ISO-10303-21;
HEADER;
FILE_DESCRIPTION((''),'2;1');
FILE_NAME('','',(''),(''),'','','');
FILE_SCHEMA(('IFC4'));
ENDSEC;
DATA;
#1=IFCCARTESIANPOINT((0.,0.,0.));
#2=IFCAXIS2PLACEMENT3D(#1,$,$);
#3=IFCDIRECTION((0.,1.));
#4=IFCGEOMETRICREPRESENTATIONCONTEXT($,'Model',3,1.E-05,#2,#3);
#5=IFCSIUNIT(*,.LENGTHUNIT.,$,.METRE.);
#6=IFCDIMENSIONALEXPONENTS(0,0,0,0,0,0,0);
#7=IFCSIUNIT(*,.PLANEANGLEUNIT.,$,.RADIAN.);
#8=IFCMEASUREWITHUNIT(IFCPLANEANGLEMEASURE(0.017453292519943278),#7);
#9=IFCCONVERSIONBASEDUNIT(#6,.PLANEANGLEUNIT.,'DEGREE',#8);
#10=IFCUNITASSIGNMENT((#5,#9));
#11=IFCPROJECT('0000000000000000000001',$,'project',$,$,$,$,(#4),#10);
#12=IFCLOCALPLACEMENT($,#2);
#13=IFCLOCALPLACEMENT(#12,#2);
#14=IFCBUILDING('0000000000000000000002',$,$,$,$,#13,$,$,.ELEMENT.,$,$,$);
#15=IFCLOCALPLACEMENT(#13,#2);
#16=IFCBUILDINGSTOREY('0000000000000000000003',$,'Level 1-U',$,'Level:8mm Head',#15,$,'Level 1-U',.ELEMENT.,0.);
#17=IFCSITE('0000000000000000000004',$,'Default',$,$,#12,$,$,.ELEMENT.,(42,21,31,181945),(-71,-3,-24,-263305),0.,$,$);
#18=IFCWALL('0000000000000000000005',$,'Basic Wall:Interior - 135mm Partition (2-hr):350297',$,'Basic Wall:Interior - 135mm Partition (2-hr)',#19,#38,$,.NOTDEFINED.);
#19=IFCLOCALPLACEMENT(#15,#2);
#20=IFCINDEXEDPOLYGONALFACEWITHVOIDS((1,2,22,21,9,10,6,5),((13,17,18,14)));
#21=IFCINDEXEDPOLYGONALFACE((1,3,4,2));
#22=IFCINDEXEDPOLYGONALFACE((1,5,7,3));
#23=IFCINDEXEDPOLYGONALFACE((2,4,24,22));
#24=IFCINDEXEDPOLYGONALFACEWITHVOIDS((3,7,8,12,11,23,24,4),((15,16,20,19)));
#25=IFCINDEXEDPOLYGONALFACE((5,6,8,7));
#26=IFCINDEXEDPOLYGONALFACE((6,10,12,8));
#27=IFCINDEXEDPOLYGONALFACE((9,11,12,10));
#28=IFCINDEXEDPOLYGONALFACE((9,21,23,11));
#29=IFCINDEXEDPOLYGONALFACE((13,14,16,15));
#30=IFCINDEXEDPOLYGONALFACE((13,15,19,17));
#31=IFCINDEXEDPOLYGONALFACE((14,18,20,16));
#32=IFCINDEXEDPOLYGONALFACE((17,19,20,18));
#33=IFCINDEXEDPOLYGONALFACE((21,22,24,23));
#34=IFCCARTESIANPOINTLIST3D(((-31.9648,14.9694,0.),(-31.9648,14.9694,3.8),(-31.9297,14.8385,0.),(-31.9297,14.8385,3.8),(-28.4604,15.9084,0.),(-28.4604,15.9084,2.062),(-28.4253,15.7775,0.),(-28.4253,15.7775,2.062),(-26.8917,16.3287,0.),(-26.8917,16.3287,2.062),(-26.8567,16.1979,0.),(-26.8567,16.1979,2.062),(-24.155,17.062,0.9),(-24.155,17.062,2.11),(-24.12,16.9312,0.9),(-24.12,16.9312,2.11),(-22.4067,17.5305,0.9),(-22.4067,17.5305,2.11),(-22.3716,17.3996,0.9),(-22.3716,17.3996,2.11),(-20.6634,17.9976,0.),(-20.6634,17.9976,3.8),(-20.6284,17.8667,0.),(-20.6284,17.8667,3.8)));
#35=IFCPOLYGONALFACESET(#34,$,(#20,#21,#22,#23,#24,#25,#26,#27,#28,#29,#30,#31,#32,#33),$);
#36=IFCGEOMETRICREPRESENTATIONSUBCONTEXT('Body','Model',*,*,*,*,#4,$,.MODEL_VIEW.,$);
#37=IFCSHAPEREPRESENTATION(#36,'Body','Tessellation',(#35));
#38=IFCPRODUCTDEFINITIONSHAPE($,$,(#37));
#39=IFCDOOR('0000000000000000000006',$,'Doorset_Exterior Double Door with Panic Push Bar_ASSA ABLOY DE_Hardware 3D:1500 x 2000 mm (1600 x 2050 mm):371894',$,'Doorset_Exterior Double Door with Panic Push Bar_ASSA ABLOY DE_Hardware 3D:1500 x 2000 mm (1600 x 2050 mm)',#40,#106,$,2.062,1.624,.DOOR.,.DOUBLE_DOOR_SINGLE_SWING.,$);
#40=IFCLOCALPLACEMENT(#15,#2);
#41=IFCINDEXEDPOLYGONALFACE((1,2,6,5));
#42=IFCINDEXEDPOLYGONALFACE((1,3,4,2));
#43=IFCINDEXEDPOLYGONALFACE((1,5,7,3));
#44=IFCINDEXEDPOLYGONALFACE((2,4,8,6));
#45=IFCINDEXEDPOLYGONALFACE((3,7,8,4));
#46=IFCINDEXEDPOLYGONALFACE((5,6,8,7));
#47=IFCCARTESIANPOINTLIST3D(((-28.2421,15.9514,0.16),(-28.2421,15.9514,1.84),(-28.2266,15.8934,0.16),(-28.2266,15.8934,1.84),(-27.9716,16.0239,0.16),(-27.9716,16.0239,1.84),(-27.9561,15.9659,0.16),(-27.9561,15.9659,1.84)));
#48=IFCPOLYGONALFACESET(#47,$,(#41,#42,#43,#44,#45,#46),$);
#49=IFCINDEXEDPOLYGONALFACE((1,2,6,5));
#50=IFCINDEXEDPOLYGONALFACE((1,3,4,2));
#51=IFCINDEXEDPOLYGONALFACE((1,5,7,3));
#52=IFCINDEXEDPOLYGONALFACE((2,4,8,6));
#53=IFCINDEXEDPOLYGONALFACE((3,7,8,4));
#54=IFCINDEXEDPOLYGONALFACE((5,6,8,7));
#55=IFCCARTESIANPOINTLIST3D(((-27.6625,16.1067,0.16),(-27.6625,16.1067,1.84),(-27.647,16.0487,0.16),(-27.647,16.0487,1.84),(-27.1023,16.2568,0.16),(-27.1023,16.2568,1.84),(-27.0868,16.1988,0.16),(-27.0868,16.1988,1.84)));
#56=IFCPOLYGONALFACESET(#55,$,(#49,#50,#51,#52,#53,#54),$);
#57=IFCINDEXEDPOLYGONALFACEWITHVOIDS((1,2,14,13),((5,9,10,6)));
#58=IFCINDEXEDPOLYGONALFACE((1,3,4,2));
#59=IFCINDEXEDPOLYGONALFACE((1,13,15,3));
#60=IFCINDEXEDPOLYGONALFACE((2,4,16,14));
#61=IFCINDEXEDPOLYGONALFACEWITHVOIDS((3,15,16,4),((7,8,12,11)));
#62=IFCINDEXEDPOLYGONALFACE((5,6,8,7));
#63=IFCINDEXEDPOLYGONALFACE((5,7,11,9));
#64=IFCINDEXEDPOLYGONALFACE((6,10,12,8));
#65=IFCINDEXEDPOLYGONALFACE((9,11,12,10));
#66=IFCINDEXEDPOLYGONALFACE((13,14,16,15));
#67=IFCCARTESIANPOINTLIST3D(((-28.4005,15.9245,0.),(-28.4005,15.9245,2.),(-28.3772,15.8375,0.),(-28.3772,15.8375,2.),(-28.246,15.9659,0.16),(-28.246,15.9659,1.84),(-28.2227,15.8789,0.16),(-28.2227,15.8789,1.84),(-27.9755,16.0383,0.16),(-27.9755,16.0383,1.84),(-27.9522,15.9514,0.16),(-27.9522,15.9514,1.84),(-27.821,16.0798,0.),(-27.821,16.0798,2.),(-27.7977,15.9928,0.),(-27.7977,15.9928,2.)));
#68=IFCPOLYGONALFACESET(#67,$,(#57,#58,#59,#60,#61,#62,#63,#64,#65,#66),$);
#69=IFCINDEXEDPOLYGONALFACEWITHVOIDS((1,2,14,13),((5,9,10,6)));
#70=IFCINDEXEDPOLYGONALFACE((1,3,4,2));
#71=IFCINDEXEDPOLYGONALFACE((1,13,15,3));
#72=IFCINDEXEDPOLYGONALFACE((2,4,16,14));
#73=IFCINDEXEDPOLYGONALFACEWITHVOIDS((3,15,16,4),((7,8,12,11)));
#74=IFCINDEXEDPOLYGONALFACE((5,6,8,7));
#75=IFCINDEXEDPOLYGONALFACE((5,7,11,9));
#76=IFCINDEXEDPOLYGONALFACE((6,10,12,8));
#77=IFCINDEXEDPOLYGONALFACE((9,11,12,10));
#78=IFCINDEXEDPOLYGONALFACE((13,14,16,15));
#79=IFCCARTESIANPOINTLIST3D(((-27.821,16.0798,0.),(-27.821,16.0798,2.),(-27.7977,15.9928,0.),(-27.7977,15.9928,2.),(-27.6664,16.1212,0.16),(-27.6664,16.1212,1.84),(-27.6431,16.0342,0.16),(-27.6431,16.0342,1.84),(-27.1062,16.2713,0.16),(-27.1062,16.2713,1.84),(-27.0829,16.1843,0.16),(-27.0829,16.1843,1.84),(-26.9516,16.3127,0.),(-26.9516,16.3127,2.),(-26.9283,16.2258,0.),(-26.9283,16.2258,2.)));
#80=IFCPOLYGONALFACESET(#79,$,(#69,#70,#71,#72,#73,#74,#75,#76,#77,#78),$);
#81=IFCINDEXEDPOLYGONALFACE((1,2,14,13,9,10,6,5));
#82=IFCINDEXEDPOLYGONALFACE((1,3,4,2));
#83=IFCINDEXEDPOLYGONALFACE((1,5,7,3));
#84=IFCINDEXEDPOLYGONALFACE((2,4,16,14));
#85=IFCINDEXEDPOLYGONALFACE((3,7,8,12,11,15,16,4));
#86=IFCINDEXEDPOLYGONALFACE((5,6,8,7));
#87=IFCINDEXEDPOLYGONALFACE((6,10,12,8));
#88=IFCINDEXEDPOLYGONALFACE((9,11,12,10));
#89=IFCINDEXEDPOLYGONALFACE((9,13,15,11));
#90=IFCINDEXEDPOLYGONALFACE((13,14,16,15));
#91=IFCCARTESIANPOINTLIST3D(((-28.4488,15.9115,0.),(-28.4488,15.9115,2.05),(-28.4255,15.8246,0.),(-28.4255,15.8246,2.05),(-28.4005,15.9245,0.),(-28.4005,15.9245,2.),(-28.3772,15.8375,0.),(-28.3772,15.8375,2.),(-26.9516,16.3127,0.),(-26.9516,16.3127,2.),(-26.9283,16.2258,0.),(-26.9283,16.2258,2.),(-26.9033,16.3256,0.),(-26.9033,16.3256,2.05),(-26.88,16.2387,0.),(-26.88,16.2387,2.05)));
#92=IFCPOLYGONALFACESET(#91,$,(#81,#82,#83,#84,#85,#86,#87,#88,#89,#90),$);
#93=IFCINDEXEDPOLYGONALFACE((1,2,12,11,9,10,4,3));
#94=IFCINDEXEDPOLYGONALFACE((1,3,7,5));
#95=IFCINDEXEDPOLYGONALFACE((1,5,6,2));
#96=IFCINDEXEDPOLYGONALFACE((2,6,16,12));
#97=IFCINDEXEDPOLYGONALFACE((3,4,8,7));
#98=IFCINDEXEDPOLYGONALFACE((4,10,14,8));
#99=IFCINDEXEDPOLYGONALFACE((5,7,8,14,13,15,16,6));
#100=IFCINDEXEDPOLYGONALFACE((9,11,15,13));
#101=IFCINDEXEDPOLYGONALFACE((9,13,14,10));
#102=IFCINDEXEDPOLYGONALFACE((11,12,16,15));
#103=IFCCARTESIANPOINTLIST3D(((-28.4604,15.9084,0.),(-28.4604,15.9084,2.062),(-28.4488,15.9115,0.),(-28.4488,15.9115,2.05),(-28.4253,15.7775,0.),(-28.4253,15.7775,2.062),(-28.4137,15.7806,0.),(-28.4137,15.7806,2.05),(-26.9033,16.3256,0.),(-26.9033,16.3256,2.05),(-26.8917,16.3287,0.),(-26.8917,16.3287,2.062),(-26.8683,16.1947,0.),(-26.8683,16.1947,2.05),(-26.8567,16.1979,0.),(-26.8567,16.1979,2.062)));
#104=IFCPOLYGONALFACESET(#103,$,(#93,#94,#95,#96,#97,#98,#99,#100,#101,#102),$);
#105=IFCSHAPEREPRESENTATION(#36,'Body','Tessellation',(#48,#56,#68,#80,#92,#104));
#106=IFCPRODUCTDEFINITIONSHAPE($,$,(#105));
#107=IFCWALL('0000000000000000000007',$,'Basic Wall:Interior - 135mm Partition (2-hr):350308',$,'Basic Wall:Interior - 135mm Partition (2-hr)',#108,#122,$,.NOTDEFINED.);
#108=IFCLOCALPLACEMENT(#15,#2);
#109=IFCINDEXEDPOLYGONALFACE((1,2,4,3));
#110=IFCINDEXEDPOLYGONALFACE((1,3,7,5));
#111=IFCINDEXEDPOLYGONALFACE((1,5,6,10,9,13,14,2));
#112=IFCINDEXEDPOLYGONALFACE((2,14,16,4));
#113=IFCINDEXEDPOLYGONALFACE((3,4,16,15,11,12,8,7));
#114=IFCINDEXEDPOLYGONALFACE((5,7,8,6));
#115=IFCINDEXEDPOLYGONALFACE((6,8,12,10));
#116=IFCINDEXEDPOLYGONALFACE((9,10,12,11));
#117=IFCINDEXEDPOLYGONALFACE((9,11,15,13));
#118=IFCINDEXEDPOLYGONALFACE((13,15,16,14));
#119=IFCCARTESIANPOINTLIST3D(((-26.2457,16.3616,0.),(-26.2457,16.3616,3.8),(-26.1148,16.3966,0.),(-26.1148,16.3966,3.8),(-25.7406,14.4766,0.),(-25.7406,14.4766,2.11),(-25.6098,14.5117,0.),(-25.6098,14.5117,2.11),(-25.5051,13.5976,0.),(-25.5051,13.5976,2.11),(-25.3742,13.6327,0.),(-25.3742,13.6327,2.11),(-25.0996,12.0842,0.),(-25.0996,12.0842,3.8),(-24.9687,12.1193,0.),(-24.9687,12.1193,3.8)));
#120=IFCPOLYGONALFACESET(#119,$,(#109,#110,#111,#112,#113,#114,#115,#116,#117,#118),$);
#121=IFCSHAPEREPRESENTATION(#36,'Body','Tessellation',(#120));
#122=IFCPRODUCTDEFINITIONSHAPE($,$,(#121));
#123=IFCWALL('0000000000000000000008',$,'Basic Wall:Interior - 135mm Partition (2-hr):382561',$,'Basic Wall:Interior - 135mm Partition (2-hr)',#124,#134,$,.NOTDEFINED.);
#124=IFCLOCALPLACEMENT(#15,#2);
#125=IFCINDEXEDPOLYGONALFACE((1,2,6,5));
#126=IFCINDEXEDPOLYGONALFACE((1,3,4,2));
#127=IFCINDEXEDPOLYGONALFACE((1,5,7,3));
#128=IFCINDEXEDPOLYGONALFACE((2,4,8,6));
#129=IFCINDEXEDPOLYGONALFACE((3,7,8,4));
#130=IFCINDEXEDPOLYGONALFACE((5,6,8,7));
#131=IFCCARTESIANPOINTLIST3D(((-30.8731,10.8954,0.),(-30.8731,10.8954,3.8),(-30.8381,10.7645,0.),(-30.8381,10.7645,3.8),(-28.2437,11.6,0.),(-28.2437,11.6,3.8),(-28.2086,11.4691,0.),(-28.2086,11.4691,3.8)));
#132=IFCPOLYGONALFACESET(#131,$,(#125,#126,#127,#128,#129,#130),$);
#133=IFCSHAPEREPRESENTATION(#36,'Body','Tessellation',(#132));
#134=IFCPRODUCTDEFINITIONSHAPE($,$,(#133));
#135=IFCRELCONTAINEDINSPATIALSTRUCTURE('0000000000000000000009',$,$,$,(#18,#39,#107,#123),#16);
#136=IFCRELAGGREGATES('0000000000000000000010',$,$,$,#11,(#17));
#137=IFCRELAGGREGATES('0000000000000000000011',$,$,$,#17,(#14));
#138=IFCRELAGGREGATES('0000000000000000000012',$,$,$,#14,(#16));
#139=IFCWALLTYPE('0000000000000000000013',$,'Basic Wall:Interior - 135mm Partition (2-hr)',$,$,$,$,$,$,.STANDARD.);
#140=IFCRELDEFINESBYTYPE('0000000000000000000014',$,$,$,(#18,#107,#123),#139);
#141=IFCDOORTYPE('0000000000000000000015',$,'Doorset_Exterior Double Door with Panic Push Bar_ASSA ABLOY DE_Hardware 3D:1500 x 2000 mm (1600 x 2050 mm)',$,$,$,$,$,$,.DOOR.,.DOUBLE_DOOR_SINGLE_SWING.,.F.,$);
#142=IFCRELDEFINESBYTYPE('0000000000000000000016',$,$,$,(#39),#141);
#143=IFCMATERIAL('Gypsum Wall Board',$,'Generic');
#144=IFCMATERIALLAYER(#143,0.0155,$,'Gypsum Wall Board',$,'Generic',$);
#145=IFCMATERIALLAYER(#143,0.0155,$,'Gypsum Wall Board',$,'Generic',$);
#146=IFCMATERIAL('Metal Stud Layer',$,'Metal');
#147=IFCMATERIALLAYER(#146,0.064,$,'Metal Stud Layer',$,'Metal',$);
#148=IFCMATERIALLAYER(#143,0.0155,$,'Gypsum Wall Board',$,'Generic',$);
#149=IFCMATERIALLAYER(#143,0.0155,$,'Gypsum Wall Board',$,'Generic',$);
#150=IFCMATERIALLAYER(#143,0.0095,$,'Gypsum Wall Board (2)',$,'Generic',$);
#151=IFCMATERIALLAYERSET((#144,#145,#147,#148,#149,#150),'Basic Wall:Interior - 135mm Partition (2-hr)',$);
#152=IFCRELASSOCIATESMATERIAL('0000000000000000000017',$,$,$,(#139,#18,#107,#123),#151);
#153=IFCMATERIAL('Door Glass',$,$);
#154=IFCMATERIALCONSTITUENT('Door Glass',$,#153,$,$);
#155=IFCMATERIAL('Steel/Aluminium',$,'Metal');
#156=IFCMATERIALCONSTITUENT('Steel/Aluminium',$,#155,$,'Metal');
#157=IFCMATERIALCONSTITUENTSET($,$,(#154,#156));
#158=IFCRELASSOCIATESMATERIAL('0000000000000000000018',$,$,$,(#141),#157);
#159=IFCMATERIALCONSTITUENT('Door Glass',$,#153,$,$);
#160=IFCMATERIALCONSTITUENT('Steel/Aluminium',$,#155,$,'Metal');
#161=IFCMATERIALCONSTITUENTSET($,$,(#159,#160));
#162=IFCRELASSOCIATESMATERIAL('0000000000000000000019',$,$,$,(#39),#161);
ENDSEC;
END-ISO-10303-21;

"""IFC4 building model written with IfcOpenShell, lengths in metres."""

from ifc_helpers import new_model, entity, si_unit, converted_unit, direction, frame, frame_2d, origin, place, context, subcontext, project, spatial, polyline, rectangle, outline, extrude, source, transform, mapped, material, layer, layer_set, layer_usage, constituent, constituent_set, type_object, type_shapes, element, fill, save


model = new_model("IFC4")

# Units and contexts
model_context = context("Model", 3, precision=1e-05, world=origin(), true_north=direction((0.0, 1.0)))
body_context = subcontext(model_context, "Body", "Model", "MODEL_VIEW")
ifc_project = project(units=[si_unit("LENGTHUNIT", "METRE"), converted_unit("PLANEANGLEUNIT", "DEGREE", entity("IfcPlaneAngleMeasure", 0.017453292519943278), si_unit("PLANEANGLEUNIT", "RADIAN"), dimensions=[0, 0, 0, 0, 0, 0, 0])], contexts=[model_context])

# Site, building, storey
site_placement = place(None, origin())
site = spatial("IfcSite", under=ifc_project, at=site_placement, Name="Default", CompositionType="ELEMENT", RefLatitude=(42, 21, 31, 181945), RefLongitude=(-71, -3, -24, -263305), RefElevation=0.0)
building_placement = place(site_placement, origin())
building = spatial("IfcBuilding", under=site, at=building_placement, CompositionType="ELEMENT")
storey_placement = place(building_placement, origin())
storey = spatial("IfcBuildingStorey", under=building, at=storey_placement, Name="Level 1-U", ObjectType="Level:8mm Head", LongName="Level 1-U", CompositionType="ELEMENT", Elevation=0.0)

# Shared definitions
ifc_material_1 = material(Name="Door Glass")
ifc_material_2 = material(Name="Steel/Aluminium", Category="Metal")

# Wall, openings, door
ifc_material_3 = material(Name="Gypsum Wall Board", Category="Generic")
ifc_layer_1 = layer(ifc_material_3, 0.0155, Name="Gypsum Wall Board", Category="Generic")
ifc_layer_2 = layer(ifc_material_3, 0.0155, Name="Gypsum Wall Board", Category="Generic")
ifc_material_4 = material(Name="Metal Stud Layer", Category="Metal")
ifc_layer_3 = layer(ifc_material_4, 0.064, Name="Metal Stud Layer", Category="Metal")
ifc_layer_4 = layer(ifc_material_3, 0.0155, Name="Gypsum Wall Board", Category="Generic")
ifc_layer_5 = layer(ifc_material_3, 0.0155, Name="Gypsum Wall Board", Category="Generic")
ifc_layer_6 = layer(ifc_material_3, 0.0095, Name="Gypsum Wall Board (2)", Category="Generic")
ifc_layer_set_1 = layer_set([ifc_layer_1, ifc_layer_2, ifc_layer_3, ifc_layer_4, ifc_layer_5, ifc_layer_6], Name="Basic Wall:Interior - 135mm Partition (2-hr)")
ifc_layer_usage_1 = layer_usage(ifc_layer_set_1, "AXIS2", "NEGATIVE", 0.0677)
wall_type_1 = type_object("IfcWallType", Name="Basic Wall:Interior - 135mm Partition (2-hr)", PredefinedType="STANDARD", material=ifc_layer_set_1)
wall_1_placement = place(storey_placement, frame((-20.6459, 17.9322, 0.0), z_axis=(0.0, 0.0, 1.0), x_axis=(-0.965926, -0.258819, 0.0)))
wall_1 = element("IfcWall", 1, at=wall_1_placement, inside=storey, type_object=wall_type_1, material=ifc_layer_usage_1, Name="Basic Wall:Interior - 135mm Partition (2-hr):350297", ObjectType="Basic Wall:Interior - 135mm Partition (2-hr)", PredefinedType="NOTDEFINED", context=body_context, shape_type="SweptSolid", body=[
    extrude(rectangle(XDim=11.7, YDim=0.1355, at=frame_2d((5.85, 0.0), x_axis=(1.0, 0.0))), origin(), (0.0, 0.0, 1.0), 3.8),
])
opening_1_placement = place(wall_1_placement, frame((8.072, 0.0677, 0.0)))
opening_1 = element("IfcOpeningElement", 2, at=opening_1_placement, cuts=wall_1, PredefinedType="OPENING", context=body_context, shape_type="SweptSolid", body=[
    extrude(rectangle(XDim=2.062, YDim=1.624, at=frame_2d((1.031, 0.812), x_axis=(-1.0, 0.0))), frame((0.0, 0.0, 0.0), z_axis=(0.0, -1.0, 0.0), x_axis=(0.0, 0.0, 1.0)), (0.0, 0.0, 1.0), 0.1355),
])
opening_2_placement = place(wall_1_placement, frame((3.6147, 0.0677, 0.9)))
element("IfcOpeningElement", 3, at=opening_2_placement, cuts=wall_1, PredefinedType="OPENING", context=body_context, shape_type="SweptSolid", body=[
    extrude(rectangle(XDim=1.21, YDim=1.81, at=frame_2d((0.605, 0.905), x_axis=(-1.0, 0.0))), frame((0.0, 0.0, 0.0), z_axis=(0.0, -1.0, 0.0), x_axis=(0.0, 0.0, 1.0)), (0.0, 0.0, 1.0), 0.1355),
])
ifc_constituent_1 = constituent(ifc_material_1, Name="Door Glass")
ifc_constituent_2 = constituent(ifc_material_2, Name="Steel/Aluminium", Category="Metal")
ifc_constituent_set_1 = constituent_set(constituents=[ifc_constituent_1, ifc_constituent_2])
ifc_constituent_3 = constituent(ifc_material_1, Name="Door Glass")
ifc_constituent_4 = constituent(ifc_material_2, Name="Steel/Aluminium", Category="Metal")
ifc_constituent_set_2 = constituent_set(constituents=[ifc_constituent_3, ifc_constituent_4])
door_type_1 = type_object("IfcDoorType", Name="Doorset_Exterior Double Door with Panic Push Bar_ASSA ABLOY DE_Hardware 3D:1500 x 2000 mm (1600 x 2050 mm)", OperationType="DOUBLE_DOOR_SINGLE_SWING", ParameterTakesPrecedence=False, PredefinedType="DOOR", material=ifc_constituent_set_2)
shared_shape_1 = source(origin(), body_context, "Body", "SweptSolid", [
    extrude(rectangle(XDim=0.06, YDim=0.28, at=frame_2d((0.0, 0.0), x_axis=(1.0, 0.0))), frame((0.362, 0.0905, 0.16), z_axis=(0.0, 0.0, 1.0), x_axis=(0.0, 1.0, 0.0)), (0.0, 0.0, 1.0), 1.68),
    extrude(rectangle(XDim=0.06, YDim=0.58, at=frame_2d((0.0, 0.0), x_axis=(1.0, 0.0))), frame((1.112, 0.0905, 0.16), z_axis=(0.0, 0.0, 1.0), x_axis=(0.0, 1.0, 0.0)), (0.0, 0.0, 1.0), 1.68),
    extrude(outline(polyline([(-0.3, -1.0), (0.3, -1.0), (0.3, 1.0), (-0.3, 1.0), (-0.3, -1.0)]), holes=[polyline([(0.14, -0.84), (-0.14, -0.84), (-0.14, 0.84), (0.14, 0.84), (0.14, -0.84)])]), frame((0.362, 0.0455, 1.0), z_axis=(0.0, 1.0, 0.0), x_axis=(-1.0, 0.0, 0.0)), (0.0, 0.0, 1.0), 0.09),
    extrude(outline(polyline([(-1.0, -0.45), (1.0, -0.45), (1.0, 0.45), (-1.0, 0.45), (-1.0, -0.45)]), holes=[polyline([(-0.84, -0.29), (-0.84, 0.29), (0.84, 0.29), (0.84, -0.29), (-0.84, -0.29)])]), frame((1.112, 0.0455, 1.0), z_axis=(0.0, 1.0, 0.0), x_axis=(0.0, 0.0, -1.0)), (0.0, 0.0, 1.0), 0.09),
    extrude(outline(polyline([(-1.0375, -0.8), (1.0125, -0.8), (1.0125, -0.75), (-0.9875, -0.75), (-0.9875, 0.75), (1.0125, 0.75), (1.0125, 0.8), (-1.0375, 0.8), (-1.0375, -0.8)])), frame((0.812, 0.0455, 1.0125), z_axis=(0.0, 1.0, 0.0), x_axis=(0.0, 0.0, -1.0)), (0.0, 0.0, 1.0), 0.09),
    extrude(outline(polyline([(-0.812, -1.034), (0.812, -1.034), (0.812, 1.028), (0.8, 1.028), (0.8, -1.022), (-0.8, -1.022), (-0.8, 1.028), (-0.812, 1.028), (-0.812, -1.034)])), frame((0.812, 0.0, 1.028), z_axis=(0.0, 1.0, 0.0), x_axis=(1.0, 0.0, 0.0)), (0.0, 0.0, 1.0), 0.1355),
])
type_shapes(door_type_1, [shared_shape_1])
door_1_placement = place(opening_1_placement, frame((0.0, 0.0, 0.0), z_axis=(0.0, 0.0, 1.0), x_axis=(-1.0, 0.0, 0.0)))
door_1 = element("IfcDoor", 4, at=door_1_placement, inside=storey, type_object=door_type_1, material=ifc_constituent_set_1, Name="Doorset_Exterior Double Door with Panic Push Bar_ASSA ABLOY DE_Hardware 3D:1500 x 2000 mm (1600 x 2050 mm):371894", ObjectType="Doorset_Exterior Double Door with Panic Push Bar_ASSA ABLOY DE_Hardware 3D:1500 x 2000 mm (1600 x 2050 mm)", OperationType="DOUBLE_DOOR_SINGLE_SWING", OverallHeight=2.062, OverallWidth=1.624, PredefinedType="DOOR", context=body_context, shape_type="MappedRepresentation", body=[
    mapped(shared_shape_1, transform((0.0, 0.0, 0.0), scale=1.0)),
])
fill(opening_1, door_1)

# Wall, opening
wall_2_placement = place(storey_placement, frame((-26.1803, 16.3791, 0.0), z_axis=(0.0, 0.0, 1.0), x_axis=(0.258819, -0.965926, 0.0)))
wall_2 = element("IfcWall", 5, at=wall_2_placement, inside=storey, type_object=wall_type_1, material=ifc_layer_usage_1, Name="Basic Wall:Interior - 135mm Partition (2-hr):350308", ObjectType="Basic Wall:Interior - 135mm Partition (2-hr)", PredefinedType="NOTDEFINED", context=body_context, shape_type="SweptSolid", body=[
    extrude(rectangle(XDim=4.4282, YDim=0.1355, at=frame_2d((2.2141, 0.0), x_axis=(-1.0, 0.0))), origin(), (0.0, 0.0, 1.0), 3.8),
])
opening_3_placement = place(wall_2_placement, frame((2.8615, 0.0677, 0.0)))
element("IfcOpeningElement", 6, at=opening_3_placement, cuts=wall_2, PredefinedType="OPENING", context=body_context, shape_type="SweptSolid", body=[
    extrude(rectangle(XDim=2.11, YDim=0.91, at=frame_2d((1.055, 0.455), x_axis=(1.0, 0.0))), frame((0.0, 0.0, 0.0), z_axis=(0.0, -1.0, 0.0), x_axis=(0.0, 0.0, 1.0)), (0.0, 0.0, 1.0), 0.1355),
])

# Wall
wall_3_placement = place(storey_placement, frame((-28.2261, 11.5345, 0.0), z_axis=(0.0, 0.0, 1.0), x_axis=(-0.965926, -0.258819, 0.0)))
element("IfcWall", 7, at=wall_3_placement, inside=storey, type_object=wall_type_1, material=ifc_layer_usage_1, Name="Basic Wall:Interior - 135mm Partition (2-hr):382561", ObjectType="Basic Wall:Interior - 135mm Partition (2-hr)", PredefinedType="NOTDEFINED", context=body_context, shape_type="SweptSolid", body=[
    extrude(rectangle(XDim=2.7222, YDim=0.1355, at=frame_2d((1.3611, 0.0), x_axis=(-1.0, 0.0))), origin(), (0.0, 0.0, 1.0), 3.8),
])

save(model, "model.ifc")
